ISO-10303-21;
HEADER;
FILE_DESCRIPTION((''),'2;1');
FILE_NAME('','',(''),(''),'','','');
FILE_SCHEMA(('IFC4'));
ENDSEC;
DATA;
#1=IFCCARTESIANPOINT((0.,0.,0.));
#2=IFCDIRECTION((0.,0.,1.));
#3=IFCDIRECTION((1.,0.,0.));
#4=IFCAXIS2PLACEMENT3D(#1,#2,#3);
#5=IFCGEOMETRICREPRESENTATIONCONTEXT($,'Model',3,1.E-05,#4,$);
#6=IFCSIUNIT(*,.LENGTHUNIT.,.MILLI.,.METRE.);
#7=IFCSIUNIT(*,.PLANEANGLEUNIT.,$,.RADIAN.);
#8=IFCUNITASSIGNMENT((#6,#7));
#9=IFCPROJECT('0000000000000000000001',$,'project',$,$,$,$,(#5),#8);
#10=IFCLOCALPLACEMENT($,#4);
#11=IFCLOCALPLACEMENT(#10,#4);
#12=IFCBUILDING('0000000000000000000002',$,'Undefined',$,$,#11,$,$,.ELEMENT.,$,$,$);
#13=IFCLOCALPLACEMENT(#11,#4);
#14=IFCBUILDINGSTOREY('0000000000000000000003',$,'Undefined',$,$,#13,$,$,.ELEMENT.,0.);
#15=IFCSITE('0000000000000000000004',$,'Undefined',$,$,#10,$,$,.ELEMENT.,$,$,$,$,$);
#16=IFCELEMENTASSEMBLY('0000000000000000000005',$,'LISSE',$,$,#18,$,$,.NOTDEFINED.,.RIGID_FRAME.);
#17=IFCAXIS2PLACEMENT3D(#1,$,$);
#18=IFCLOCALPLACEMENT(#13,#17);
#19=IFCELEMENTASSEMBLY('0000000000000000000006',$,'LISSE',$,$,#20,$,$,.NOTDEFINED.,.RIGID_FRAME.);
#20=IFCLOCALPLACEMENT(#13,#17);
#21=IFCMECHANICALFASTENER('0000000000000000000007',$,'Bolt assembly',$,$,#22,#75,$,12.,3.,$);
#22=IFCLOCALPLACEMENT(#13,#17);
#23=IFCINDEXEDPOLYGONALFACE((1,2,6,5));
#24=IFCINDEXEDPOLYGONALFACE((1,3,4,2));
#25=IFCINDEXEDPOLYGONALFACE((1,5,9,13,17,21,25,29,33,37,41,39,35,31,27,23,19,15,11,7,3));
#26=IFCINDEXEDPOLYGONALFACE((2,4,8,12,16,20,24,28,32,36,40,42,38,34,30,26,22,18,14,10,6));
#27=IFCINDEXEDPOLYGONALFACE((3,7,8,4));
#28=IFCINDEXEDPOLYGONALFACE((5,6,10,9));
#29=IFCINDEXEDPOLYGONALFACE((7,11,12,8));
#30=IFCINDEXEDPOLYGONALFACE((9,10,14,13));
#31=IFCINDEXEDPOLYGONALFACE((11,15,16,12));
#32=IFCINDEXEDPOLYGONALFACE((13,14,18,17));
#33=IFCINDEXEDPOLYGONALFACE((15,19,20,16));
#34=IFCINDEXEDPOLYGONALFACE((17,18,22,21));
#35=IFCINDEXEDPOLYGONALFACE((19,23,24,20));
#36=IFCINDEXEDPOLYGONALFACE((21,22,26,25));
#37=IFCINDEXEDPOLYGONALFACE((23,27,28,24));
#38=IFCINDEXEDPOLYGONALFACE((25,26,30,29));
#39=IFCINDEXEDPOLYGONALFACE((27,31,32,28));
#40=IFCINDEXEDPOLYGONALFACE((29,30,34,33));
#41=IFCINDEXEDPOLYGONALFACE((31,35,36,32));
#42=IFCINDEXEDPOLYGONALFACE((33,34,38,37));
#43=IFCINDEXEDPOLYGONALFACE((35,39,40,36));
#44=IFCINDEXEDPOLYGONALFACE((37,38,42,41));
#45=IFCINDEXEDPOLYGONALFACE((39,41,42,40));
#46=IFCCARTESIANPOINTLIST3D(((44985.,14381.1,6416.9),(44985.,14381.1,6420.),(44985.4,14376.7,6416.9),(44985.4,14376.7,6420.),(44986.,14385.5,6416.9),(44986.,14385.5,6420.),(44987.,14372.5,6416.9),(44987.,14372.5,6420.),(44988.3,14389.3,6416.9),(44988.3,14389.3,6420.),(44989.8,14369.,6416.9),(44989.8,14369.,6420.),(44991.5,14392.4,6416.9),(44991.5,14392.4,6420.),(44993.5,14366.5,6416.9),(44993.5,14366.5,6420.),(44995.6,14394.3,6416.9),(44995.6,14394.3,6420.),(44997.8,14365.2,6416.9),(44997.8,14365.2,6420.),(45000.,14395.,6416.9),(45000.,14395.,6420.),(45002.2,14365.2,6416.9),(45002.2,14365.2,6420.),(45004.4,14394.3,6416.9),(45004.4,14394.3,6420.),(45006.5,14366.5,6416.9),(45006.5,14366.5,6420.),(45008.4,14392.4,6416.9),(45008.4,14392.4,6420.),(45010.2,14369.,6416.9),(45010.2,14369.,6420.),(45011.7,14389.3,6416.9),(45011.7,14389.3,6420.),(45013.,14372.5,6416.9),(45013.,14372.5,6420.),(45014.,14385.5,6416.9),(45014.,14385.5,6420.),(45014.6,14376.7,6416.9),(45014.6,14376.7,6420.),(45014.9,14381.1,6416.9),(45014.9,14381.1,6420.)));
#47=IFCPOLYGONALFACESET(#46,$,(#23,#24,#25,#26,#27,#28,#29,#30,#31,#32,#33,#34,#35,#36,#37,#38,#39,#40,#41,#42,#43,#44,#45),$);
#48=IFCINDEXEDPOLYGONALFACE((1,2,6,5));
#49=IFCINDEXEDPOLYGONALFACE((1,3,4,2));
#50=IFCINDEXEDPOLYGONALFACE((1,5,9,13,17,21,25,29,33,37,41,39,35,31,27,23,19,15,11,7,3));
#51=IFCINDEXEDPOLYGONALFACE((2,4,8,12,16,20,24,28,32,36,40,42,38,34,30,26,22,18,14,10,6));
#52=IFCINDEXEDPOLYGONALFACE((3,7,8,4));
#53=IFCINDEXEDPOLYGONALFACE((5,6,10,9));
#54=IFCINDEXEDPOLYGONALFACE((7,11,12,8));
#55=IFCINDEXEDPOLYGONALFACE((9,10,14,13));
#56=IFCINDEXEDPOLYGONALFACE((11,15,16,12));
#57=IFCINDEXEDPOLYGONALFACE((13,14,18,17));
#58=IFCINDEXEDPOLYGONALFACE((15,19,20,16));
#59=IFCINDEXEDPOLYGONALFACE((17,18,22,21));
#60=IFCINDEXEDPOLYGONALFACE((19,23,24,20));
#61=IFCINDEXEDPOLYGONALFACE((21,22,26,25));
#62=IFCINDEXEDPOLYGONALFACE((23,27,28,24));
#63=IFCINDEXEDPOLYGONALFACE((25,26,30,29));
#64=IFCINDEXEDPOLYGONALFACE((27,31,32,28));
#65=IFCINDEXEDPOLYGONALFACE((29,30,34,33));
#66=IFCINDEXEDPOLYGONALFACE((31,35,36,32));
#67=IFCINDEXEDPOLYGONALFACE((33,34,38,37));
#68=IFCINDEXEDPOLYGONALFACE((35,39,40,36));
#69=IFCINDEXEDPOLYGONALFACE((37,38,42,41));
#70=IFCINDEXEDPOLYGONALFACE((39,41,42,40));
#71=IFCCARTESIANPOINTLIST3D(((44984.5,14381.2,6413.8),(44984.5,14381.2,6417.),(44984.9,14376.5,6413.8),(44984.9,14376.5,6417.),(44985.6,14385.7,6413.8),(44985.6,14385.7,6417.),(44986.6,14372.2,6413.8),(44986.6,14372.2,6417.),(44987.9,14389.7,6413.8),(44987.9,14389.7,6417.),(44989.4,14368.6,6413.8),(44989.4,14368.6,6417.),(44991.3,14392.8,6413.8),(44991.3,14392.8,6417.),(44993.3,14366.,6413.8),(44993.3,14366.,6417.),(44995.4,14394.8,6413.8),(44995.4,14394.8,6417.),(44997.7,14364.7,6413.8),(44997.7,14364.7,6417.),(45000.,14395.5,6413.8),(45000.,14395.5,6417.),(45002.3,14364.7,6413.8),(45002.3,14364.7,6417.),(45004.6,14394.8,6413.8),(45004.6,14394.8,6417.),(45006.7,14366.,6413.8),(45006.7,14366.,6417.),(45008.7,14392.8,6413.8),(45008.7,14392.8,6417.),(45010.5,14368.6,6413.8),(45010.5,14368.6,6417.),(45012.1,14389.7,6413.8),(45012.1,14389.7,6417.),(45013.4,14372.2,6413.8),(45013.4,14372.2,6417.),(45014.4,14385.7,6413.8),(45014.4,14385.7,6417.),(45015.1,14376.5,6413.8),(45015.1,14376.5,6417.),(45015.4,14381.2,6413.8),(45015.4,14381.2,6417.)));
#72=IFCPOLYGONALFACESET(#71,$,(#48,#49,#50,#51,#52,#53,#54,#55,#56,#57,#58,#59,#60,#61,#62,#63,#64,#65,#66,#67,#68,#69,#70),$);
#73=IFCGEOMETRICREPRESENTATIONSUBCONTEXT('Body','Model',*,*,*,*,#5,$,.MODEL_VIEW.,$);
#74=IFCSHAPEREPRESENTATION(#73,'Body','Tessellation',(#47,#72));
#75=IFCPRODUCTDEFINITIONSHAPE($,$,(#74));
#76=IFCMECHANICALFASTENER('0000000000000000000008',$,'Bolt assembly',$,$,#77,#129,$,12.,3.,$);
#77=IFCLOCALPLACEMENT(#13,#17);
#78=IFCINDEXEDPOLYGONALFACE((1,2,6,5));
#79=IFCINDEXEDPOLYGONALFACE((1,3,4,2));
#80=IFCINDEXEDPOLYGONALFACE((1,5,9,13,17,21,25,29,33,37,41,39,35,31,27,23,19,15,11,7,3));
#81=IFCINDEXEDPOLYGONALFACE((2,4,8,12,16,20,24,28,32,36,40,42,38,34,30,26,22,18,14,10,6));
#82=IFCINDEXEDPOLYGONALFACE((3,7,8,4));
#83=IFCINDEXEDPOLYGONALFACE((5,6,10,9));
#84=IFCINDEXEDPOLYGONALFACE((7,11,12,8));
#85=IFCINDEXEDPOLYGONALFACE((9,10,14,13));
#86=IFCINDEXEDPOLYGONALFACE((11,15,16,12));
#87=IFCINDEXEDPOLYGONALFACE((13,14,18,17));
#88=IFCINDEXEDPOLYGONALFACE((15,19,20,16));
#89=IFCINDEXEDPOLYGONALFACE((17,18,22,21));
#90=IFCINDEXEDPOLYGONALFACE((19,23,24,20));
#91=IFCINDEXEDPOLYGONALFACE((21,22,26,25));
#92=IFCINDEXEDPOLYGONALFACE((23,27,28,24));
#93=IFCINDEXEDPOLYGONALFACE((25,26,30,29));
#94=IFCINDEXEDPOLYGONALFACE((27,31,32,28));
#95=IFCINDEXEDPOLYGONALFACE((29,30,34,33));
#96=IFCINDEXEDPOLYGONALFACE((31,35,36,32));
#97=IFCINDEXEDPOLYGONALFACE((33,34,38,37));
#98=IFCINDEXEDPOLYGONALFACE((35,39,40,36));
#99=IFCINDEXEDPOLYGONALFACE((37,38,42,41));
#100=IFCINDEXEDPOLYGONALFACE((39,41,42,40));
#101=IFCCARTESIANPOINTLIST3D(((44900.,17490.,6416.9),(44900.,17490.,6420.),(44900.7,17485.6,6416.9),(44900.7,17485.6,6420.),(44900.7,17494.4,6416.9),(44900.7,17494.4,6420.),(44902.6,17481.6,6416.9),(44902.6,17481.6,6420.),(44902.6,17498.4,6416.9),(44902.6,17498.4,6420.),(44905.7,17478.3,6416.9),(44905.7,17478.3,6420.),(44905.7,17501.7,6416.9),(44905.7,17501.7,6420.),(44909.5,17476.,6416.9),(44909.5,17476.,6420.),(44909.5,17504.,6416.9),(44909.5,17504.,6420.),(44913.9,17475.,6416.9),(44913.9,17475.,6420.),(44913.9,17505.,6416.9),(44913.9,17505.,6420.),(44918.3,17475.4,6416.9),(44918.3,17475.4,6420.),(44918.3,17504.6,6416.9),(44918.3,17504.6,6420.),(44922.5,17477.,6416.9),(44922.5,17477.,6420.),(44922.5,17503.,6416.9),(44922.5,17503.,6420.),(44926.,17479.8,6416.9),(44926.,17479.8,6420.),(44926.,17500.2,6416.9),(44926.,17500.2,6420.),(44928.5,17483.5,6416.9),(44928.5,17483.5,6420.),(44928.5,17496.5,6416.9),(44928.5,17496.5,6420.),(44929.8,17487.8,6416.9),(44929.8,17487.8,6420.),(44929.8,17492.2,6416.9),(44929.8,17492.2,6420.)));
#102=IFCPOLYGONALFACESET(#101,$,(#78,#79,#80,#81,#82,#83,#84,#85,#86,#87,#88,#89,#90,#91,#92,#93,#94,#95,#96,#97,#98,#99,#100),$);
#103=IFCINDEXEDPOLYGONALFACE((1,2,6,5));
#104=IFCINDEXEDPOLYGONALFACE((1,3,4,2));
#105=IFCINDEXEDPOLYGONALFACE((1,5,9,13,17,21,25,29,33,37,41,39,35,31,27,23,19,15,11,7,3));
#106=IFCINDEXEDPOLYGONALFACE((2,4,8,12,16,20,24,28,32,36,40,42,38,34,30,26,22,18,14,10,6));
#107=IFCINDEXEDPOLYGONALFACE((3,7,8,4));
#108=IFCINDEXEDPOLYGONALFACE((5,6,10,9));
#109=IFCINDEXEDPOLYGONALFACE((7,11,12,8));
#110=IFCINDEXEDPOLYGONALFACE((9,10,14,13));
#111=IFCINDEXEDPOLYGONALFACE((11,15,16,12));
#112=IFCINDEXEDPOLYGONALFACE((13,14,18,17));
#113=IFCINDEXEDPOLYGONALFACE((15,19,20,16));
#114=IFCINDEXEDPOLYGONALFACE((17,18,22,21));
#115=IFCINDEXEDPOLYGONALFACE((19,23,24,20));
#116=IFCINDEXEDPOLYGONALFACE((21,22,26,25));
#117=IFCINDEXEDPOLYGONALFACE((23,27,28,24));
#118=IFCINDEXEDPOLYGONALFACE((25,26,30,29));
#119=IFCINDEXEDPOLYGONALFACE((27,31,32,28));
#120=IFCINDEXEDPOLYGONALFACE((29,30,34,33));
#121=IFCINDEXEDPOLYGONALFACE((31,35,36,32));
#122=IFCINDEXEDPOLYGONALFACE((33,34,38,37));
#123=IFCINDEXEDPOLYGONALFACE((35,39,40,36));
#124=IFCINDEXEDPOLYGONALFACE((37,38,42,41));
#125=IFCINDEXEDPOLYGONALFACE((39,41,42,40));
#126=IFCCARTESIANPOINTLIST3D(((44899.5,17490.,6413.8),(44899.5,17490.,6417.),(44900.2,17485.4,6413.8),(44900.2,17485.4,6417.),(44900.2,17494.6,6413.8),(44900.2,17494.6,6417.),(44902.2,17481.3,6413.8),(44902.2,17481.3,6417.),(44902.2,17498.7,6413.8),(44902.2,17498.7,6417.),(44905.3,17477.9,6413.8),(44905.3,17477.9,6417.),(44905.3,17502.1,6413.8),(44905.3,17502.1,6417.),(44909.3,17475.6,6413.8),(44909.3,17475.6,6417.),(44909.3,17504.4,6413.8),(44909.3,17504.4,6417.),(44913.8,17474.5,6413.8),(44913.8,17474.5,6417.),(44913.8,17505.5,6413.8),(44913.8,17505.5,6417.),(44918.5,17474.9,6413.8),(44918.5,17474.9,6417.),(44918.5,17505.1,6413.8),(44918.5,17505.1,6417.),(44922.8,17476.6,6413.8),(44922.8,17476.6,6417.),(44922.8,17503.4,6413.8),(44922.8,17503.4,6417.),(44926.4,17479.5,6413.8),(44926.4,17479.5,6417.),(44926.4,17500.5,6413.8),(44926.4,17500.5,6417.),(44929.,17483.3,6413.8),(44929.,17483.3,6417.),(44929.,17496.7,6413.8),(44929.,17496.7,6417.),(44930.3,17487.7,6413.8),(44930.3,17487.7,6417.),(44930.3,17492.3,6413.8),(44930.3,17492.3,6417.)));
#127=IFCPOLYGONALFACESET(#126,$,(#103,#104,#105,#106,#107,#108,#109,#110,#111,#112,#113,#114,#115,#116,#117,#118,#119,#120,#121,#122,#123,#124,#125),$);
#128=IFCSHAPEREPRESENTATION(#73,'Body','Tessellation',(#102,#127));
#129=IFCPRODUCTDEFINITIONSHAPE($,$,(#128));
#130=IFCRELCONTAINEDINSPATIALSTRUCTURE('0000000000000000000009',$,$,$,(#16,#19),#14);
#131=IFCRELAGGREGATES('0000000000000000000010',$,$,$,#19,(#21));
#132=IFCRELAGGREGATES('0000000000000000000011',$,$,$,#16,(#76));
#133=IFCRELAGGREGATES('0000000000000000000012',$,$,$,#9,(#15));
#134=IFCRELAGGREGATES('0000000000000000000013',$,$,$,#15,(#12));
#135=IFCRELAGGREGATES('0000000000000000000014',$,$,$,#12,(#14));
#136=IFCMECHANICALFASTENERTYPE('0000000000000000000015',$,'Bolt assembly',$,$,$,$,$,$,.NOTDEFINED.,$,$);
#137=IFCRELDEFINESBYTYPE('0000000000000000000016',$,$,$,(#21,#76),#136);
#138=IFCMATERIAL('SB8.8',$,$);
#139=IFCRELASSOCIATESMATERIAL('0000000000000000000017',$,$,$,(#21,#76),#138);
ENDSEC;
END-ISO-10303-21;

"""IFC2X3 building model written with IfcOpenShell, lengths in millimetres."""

from ifc_helpers import new_model, si_unit, frame, origin_with_axes, origin_2d_with_axis, place, context, subcontext, project, spatial, circle, extrude, source, transform, mapped, material, type_object, element, aggregate, save


model = new_model("IFC2X3")

# Units and contexts
model_context = context("Model", 3, precision=1e-05, world=origin_with_axes())
body_context = subcontext(model_context, "Body", "Model", "MODEL_VIEW")
ifc_project = project(units=[si_unit("LENGTHUNIT", "METRE", prefix="MILLI"), si_unit("PLANEANGLEUNIT", "RADIAN")], contexts=[model_context])

# Site, building, storey
site_placement = place(None, origin_with_axes())
site = spatial("IfcSite", under=ifc_project, at=site_placement, Name="Undefined", CompositionType="ELEMENT")
building_placement = place(site_placement, origin_with_axes())
building = spatial("IfcBuilding", under=site, at=building_placement, Name="Undefined", CompositionType="ELEMENT")
storey_placement = place(building_placement, origin_with_axes())
storey = spatial("IfcBuildingStorey", under=building, at=storey_placement, Name="Undefined", CompositionType="ELEMENT", Elevation=0.0)

# Element assembly
assembly_1_placement = place(storey_placement, origin_with_axes())
assembly_1 = element("IfcElementAssembly", 1, at=assembly_1_placement, inside=storey, Name="LISSE", AssemblyPlace="NOTDEFINED", PredefinedType="RIGID_FRAME")

# Shared definitions
ifc_material_1 = material(Name="SB8.8")
mechanical_fastener_type = type_object("IfcMechanicalFastenerType", Name="Bolt assembly")

# Element assembly, mechanical fastener
assembly_2_placement = place(storey_placement, origin_with_axes())
assembly_2 = element("IfcElementAssembly", 2, at=assembly_2_placement, inside=storey, Name="LISSE", AssemblyPlace="NOTDEFINED", PredefinedType="RIGID_FRAME")
shared_shape_1 = source(origin_with_axes(), body_context, "Body", "SweptSolid", [
    extrude(circle(Radius=15.0, at=origin_2d_with_axis()), frame((0.0, 0.0, 0.0), z_axis=(0.0, 1.0, 0.0), x_axis=(1.0, 0.0, 0.0)), (0.0, 0.0, 1.0), 3.1),
    extrude(circle(Radius=15.5, at=origin_2d_with_axis()), frame((0.0, 3.0, 0.0), z_axis=(0.0, 1.0, 0.0), x_axis=(1.0, 0.0, 0.0)), (0.0, 0.0, 1.0), 3.2),
])
mechanical_fastener_1_placement = place(assembly_2_placement, frame((45000.0, 14380.0, 6420.0), z_axis=(-1.0, 0.0, 0.0), x_axis=(0.0, 1.0, 0.0)))
mechanical_fastener_1 = element("IfcMechanicalFastener", 3, at=mechanical_fastener_1_placement, type_object=mechanical_fastener_type, material=ifc_material_1, Name="Bolt assembly", NominalDiameter=12.0, NominalLength=3.0, context=body_context, shape_type="MappedRepresentation", body=[
    mapped(shared_shape_1, transform((0.0, 0.0, 0.0))),
])
aggregate(assembly_2, [mechanical_fastener_1])

# Mechanical fastener
shared_shape_2 = source(origin_with_axes(), body_context, "Body", "SweptSolid", [
    extrude(circle(Radius=15.0, at=origin_2d_with_axis()), frame((0.0, 0.0, 0.0), z_axis=(0.0, 1.0, 0.0), x_axis=(1.0, 0.0, 0.0)), (0.0, 0.0, 1.0), 3.1),
    extrude(circle(Radius=15.5, at=origin_2d_with_axis()), frame((0.0, 3.0, 0.0), z_axis=(0.0, 1.0, 0.0), x_axis=(1.0, 0.0, 0.0)), (0.0, 0.0, 1.0), 3.2),
])
mechanical_fastener_2_placement = place(assembly_1_placement, frame((44915.0, 17490.0, 6420.0), z_axis=(0.0, -1.0, 0.0), x_axis=(-1.0, 0.0, 0.0)))
mechanical_fastener_2 = element("IfcMechanicalFastener", 4, at=mechanical_fastener_2_placement, type_object=mechanical_fastener_type, material=ifc_material_1, Name="Bolt assembly", NominalDiameter=12.0, NominalLength=3.0, context=body_context, shape_type="MappedRepresentation", body=[
    mapped(shared_shape_2, transform((0.0, 0.0, 0.0))),
])
aggregate(assembly_1, [mechanical_fastener_2])

save(model, "model.ifc")
